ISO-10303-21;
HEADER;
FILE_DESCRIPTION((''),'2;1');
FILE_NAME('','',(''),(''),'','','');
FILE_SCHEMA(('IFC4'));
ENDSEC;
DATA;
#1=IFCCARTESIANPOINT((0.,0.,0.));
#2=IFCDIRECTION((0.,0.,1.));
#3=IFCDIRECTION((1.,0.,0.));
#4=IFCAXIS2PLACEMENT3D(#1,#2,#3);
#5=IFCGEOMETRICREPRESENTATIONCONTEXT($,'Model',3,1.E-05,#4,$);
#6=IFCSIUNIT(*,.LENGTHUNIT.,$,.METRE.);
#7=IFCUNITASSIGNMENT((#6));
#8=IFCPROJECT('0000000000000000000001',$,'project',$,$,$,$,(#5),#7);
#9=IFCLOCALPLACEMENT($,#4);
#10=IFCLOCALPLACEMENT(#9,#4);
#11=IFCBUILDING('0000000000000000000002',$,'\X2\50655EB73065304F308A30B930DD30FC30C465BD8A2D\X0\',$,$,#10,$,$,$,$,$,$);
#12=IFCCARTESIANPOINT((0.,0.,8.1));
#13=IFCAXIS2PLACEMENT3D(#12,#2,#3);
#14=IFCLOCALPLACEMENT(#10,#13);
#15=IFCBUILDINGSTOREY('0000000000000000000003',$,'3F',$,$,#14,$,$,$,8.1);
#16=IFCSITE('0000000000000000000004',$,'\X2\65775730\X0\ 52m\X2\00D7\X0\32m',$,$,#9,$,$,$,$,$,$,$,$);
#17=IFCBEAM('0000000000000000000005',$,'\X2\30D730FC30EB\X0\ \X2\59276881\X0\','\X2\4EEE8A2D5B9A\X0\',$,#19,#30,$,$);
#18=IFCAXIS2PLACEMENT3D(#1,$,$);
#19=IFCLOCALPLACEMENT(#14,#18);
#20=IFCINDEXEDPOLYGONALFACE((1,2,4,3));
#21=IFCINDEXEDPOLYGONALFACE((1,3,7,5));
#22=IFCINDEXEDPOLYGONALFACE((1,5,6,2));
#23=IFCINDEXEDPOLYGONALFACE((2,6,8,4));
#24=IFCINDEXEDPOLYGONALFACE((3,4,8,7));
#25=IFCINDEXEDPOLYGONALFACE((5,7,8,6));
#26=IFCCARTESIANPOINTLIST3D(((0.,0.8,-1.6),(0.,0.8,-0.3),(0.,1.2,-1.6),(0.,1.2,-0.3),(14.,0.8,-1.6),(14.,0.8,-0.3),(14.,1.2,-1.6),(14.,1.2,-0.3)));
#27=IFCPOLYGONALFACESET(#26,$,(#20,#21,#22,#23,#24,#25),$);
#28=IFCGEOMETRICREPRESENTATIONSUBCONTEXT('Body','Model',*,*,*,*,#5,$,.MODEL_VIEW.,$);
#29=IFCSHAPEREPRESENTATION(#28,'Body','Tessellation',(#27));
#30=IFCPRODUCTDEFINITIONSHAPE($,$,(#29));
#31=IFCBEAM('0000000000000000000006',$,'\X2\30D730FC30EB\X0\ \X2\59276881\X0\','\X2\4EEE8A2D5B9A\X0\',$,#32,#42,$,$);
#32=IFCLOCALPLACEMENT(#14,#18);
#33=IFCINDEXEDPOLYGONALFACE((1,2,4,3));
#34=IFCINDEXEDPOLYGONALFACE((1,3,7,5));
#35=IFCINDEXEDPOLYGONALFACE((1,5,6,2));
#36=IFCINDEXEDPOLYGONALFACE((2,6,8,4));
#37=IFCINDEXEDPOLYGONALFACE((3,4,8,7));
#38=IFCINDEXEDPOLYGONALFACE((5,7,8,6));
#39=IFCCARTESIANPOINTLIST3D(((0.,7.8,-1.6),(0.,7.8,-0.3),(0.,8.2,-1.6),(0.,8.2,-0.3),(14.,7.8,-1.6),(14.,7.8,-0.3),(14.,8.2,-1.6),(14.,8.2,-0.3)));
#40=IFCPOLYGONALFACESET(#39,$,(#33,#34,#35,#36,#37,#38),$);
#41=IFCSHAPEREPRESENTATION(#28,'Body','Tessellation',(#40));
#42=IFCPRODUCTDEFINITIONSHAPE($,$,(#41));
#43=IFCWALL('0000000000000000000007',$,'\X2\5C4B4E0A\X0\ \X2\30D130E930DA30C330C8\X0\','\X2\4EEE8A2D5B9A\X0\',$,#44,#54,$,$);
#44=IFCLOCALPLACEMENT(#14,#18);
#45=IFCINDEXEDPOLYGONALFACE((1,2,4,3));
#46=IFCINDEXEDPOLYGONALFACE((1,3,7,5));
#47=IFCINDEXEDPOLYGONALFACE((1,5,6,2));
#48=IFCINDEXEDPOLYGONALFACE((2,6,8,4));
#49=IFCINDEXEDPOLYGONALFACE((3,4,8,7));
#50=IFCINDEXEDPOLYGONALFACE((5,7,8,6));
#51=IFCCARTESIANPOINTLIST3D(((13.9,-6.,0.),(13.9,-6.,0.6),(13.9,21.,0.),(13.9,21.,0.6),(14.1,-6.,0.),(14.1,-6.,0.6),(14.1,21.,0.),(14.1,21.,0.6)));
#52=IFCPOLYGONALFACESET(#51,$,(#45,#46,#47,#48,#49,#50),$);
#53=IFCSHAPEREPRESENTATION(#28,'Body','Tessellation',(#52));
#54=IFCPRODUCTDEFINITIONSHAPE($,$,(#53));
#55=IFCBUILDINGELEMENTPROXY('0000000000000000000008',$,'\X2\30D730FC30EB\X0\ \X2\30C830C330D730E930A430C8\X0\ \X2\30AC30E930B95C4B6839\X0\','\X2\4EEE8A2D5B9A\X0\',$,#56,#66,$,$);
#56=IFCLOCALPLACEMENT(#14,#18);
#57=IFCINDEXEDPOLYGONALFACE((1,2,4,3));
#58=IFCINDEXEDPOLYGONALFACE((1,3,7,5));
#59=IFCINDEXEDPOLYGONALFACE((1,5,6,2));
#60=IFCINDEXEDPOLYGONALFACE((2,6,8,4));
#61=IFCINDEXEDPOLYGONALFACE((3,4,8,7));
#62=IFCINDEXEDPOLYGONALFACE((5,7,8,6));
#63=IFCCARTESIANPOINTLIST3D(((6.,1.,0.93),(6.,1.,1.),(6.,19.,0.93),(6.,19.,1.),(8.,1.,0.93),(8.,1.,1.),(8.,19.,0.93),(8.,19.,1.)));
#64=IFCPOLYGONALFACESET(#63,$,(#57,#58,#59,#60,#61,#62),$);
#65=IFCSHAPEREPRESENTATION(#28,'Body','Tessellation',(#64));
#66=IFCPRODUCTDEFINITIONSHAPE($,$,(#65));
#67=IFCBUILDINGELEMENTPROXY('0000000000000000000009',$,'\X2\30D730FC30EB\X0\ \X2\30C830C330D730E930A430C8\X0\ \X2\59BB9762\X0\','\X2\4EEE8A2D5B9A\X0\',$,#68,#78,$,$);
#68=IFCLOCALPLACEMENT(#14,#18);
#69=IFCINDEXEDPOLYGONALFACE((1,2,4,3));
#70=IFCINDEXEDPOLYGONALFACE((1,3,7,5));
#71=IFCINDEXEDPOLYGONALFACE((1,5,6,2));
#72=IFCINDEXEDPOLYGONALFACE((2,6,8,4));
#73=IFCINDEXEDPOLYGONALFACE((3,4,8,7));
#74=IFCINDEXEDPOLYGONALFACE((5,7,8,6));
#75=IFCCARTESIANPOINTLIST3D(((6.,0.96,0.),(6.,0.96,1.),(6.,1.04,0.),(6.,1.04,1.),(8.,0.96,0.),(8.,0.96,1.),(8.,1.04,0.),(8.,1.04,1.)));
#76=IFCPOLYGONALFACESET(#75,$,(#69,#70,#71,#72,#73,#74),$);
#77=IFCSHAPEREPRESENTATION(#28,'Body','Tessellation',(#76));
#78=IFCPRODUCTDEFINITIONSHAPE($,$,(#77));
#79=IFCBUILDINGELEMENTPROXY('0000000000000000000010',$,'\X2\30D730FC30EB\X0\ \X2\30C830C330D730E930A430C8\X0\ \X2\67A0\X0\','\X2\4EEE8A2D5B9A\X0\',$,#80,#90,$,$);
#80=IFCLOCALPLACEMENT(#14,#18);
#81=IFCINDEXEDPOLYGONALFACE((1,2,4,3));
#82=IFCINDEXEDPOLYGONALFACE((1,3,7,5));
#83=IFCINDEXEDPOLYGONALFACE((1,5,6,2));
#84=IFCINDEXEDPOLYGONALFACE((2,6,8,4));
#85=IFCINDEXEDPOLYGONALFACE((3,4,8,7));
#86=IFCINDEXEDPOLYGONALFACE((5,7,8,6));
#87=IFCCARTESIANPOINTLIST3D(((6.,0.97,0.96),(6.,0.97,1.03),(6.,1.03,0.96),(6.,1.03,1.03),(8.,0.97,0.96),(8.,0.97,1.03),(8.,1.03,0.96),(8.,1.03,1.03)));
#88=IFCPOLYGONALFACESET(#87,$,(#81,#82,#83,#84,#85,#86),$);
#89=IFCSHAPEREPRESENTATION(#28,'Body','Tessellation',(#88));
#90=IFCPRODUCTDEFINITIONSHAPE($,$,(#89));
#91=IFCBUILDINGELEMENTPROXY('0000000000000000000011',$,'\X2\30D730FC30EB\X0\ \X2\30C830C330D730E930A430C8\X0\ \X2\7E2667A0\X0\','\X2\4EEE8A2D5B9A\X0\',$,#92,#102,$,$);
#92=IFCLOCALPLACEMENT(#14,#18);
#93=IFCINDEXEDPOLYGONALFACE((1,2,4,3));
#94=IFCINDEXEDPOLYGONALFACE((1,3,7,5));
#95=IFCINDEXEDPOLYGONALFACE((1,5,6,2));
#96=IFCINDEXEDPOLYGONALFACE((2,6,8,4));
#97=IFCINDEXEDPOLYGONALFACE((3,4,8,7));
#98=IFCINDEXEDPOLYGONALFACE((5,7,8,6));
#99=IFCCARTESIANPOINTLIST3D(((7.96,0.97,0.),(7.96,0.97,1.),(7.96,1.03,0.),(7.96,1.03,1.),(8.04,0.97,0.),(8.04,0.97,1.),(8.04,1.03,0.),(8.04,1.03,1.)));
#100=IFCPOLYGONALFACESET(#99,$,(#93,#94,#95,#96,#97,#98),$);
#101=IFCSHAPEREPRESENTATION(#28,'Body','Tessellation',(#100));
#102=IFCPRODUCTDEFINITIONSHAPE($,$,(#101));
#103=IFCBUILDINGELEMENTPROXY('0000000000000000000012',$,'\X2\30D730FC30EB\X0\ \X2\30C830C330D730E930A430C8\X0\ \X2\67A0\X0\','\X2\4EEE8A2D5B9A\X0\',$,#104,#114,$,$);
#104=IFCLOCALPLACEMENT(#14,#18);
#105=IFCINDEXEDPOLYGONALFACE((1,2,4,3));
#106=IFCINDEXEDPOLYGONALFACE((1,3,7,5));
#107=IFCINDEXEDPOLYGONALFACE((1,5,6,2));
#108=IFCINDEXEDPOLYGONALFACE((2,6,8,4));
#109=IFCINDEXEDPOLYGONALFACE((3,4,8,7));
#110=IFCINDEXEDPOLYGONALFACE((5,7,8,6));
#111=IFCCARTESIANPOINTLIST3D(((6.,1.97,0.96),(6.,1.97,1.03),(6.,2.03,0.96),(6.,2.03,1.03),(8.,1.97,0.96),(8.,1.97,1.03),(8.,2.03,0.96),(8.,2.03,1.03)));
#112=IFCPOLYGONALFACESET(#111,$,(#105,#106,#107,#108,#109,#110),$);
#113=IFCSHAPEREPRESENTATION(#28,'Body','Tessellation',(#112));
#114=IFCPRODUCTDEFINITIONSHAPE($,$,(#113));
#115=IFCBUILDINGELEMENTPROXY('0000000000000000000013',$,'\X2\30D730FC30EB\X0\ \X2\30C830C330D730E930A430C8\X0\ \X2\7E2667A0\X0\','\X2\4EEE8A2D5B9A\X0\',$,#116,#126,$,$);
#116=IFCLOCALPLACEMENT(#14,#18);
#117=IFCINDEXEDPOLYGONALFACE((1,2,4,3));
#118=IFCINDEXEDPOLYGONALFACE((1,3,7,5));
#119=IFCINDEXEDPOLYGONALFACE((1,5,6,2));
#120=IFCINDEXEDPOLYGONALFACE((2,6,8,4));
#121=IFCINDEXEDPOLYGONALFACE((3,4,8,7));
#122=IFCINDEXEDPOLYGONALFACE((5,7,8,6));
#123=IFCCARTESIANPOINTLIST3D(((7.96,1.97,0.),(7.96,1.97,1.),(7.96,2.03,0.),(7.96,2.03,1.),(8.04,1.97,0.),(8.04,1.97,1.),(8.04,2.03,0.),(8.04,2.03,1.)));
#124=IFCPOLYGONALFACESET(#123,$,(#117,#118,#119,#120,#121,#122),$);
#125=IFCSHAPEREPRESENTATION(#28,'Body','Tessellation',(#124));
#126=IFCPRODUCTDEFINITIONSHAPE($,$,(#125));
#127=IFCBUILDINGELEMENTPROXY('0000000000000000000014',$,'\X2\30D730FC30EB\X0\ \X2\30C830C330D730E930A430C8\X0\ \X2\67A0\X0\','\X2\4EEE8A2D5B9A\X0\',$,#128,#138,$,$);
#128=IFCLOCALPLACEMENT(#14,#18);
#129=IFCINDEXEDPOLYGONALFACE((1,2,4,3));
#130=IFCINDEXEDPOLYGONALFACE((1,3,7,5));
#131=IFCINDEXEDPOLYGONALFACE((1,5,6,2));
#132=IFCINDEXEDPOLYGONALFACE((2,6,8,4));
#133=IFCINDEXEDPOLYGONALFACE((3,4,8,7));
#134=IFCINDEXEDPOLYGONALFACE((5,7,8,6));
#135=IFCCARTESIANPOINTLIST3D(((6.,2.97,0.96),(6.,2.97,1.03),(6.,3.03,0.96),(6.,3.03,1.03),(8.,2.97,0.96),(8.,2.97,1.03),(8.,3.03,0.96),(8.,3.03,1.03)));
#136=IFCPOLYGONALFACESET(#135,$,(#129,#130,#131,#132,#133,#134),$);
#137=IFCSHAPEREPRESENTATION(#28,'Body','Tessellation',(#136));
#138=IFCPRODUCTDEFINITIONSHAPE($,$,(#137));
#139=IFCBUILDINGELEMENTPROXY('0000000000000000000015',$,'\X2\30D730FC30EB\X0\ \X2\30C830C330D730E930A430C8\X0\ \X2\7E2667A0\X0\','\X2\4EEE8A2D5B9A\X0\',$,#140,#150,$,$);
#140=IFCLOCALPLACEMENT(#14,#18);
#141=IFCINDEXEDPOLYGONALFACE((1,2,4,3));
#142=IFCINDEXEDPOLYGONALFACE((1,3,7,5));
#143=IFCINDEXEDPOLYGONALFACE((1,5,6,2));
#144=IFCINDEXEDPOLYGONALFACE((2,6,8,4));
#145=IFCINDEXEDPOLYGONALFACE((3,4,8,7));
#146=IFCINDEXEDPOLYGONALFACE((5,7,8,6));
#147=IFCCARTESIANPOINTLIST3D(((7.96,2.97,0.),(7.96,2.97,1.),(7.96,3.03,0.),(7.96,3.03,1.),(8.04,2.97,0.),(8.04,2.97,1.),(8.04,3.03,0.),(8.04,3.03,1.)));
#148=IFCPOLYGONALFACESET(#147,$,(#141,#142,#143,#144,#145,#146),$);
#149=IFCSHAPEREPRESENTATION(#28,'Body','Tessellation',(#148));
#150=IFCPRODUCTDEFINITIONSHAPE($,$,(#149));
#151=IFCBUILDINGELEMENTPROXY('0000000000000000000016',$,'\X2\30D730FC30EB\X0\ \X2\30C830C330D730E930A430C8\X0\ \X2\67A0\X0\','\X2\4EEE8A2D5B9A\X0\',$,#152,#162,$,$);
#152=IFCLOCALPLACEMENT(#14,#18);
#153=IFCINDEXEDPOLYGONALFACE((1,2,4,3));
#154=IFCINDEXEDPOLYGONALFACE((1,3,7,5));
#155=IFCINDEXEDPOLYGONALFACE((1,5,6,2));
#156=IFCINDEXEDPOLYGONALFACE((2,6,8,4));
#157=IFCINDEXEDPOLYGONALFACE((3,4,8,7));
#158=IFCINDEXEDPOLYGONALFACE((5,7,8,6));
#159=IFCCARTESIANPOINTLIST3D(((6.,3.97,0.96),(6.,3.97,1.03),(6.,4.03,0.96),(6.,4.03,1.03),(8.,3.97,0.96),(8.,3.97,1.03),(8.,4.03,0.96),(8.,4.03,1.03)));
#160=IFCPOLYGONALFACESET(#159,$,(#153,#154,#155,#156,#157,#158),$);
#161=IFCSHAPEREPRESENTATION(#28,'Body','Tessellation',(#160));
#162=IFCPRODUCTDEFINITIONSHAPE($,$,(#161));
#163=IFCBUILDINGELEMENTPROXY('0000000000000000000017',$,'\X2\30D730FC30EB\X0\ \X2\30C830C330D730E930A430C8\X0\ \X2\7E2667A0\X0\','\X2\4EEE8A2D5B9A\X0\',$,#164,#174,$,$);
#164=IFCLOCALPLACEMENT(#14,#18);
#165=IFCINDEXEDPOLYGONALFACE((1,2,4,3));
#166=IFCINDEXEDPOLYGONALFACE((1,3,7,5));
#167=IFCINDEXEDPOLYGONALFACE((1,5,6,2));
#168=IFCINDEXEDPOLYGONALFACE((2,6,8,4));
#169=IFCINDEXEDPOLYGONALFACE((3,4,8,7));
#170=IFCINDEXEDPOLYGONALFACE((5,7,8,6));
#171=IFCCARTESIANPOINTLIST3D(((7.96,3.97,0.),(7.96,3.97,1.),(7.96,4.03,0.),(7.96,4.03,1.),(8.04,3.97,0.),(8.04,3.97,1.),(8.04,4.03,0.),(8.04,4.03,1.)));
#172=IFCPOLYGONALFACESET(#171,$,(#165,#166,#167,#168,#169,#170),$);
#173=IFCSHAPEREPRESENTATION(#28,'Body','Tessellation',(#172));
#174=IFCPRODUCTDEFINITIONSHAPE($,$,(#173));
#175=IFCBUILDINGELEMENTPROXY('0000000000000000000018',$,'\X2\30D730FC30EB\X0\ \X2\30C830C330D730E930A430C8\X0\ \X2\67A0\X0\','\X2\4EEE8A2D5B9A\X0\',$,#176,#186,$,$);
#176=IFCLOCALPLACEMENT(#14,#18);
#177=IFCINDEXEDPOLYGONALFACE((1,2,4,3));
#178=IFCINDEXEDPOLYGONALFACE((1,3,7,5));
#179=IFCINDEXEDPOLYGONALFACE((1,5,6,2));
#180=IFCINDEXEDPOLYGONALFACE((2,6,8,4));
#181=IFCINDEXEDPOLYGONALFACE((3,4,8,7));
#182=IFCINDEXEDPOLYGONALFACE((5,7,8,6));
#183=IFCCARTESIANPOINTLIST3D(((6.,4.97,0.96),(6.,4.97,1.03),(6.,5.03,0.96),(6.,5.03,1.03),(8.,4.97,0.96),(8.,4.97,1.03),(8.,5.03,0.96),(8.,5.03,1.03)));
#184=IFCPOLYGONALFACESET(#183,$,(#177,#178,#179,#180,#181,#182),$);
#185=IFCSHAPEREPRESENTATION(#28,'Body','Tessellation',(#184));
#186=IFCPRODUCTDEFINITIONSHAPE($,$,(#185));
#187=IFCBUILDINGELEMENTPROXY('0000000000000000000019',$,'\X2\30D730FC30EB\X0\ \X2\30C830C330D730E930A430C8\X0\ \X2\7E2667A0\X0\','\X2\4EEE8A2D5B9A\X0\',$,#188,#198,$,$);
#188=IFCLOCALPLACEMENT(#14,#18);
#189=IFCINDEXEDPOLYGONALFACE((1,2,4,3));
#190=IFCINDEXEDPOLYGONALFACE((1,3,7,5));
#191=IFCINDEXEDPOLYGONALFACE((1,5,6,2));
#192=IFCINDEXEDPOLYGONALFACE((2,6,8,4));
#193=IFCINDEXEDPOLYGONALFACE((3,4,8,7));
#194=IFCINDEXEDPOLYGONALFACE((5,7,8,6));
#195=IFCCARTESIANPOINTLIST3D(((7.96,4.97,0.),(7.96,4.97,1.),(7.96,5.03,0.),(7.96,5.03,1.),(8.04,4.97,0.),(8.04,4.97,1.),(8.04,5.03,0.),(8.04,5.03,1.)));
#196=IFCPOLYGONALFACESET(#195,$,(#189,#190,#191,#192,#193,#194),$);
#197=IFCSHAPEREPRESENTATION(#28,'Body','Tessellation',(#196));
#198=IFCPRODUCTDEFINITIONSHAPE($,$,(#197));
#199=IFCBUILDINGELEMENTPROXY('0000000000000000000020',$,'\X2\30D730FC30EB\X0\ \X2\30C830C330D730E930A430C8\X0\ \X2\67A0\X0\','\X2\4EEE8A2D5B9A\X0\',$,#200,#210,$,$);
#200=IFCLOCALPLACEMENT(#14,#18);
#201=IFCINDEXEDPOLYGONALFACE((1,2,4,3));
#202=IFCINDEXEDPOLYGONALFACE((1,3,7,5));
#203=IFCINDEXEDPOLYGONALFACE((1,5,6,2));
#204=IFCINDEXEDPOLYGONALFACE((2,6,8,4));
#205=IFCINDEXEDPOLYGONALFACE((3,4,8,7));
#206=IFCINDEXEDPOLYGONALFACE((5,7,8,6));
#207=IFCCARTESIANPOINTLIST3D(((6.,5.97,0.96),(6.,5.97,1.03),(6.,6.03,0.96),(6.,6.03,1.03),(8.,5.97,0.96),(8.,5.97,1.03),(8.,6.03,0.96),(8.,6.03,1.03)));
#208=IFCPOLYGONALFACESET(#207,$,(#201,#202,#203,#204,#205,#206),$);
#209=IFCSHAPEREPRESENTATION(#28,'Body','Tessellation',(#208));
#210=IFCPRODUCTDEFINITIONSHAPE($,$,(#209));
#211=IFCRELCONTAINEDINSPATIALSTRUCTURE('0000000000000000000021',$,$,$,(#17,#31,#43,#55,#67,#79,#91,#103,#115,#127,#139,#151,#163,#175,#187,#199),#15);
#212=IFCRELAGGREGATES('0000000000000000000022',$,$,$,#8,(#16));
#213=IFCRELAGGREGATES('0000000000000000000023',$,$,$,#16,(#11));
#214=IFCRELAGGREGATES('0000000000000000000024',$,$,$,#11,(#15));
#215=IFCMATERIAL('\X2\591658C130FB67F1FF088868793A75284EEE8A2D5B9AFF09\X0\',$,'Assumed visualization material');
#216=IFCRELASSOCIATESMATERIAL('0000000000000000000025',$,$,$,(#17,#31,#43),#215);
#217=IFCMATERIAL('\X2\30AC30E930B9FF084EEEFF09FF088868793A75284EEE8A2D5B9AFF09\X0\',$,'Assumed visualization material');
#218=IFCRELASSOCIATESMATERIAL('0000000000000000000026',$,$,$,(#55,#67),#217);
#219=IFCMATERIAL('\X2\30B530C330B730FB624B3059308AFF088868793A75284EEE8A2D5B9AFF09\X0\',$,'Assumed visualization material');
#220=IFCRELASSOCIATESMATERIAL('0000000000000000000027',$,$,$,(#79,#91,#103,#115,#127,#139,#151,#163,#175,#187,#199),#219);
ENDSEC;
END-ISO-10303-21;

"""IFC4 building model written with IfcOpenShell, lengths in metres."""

from ifc_helpers import new_model, si_unit, frame, origin_with_axes, place, context, subcontext, project, spatial, rectangle, extrude, material, element, save


model = new_model("IFC4")

# Units and contexts
model_context = context("Model", 3, precision=1e-05, world=origin_with_axes())
body_context = subcontext(model_context, "Body", "Model", "MODEL_VIEW")
ifc_project = project(units=[si_unit("LENGTHUNIT", "METRE")], contexts=[model_context])

# Site, building, storey
site_placement = place(None, origin_with_axes())
site = spatial("IfcSite", under=ifc_project, at=site_placement, Name="敷地 52m×32m")
building_placement = place(site_placement, origin_with_axes())
building = spatial("IfcBuilding", under=site, at=building_placement, Name="健康づくりスポーツ施設")
storey_placement = place(building_placement, frame((0.0, 0.0, 8.1), z_axis=(0.0, 0.0, 1.0), x_axis=(1.0, 0.0, 0.0)))
storey = spatial("IfcBuildingStorey", under=building, at=storey_placement, Name="3F", Elevation=8.1)

# Beams
ifc_material_1 = material(Name="外壁・柱（表示用仮設定）", Category="Assumed visualization material")
for number, where, z_axis, x_axis, name in (
    (1, (7.0, 1.0, -1.6), (0.0, 0.0, 1.0), (1.0, 0.0, 0.0), "プール 大梁"),
    (2, (7.0, 8.0, -1.6), (0.0, 0.0, 1.0), (1.0, 0.0, 0.0), "プール 大梁"),
):
    element("IfcBeam", number, at=place(storey_placement, frame(where, z_axis=z_axis, x_axis=x_axis)), inside=storey, material=ifc_material_1, Name=name, Description="仮設定", context=body_context, shape_type="SweptSolid", body=[
        extrude(rectangle(XDim=14.0, YDim=0.4), origin_with_axes(), (0.0, 0.0, 1.0), 1.3),
    ])

# Wall
wall_placement = place(storey_placement, frame((14.0, 7.5, 0.0), z_axis=(0.0, 0.0, 1.0), x_axis=(1.0, 0.0, 0.0)))
element("IfcWall", 3, at=wall_placement, inside=storey, material=ifc_material_1, Name="屋上 パラペット", Description="仮設定", context=body_context, shape_type="SweptSolid", body=[
    extrude(rectangle(XDim=0.2, YDim=27.0), origin_with_axes(), (0.0, 0.0, 1.0), 0.6),
])

# Building element proxies
ifc_material_2 = material(Name="ガラス（仮）（表示用仮設定）", Category="Assumed visualization material")
proxy_1_placement = place(storey_placement, frame((7.0, 10.0, 0.93), z_axis=(0.0, 0.0, 1.0), x_axis=(1.0, 0.0, 0.0)))
element("IfcBuildingElementProxy", 4, at=proxy_1_placement, inside=storey, material=ifc_material_2, Name="プール トップライト ガラス屋根", Description="仮設定", context=body_context, shape_type="SweptSolid", body=[
    extrude(rectangle(XDim=2.0, YDim=18.0), origin_with_axes(), (0.0, 0.0, 1.0), 0.07),
])
proxy_2_placement = place(storey_placement, frame((7.0, 1.0, 0.0), z_axis=(0.0, 0.0, 1.0), x_axis=(1.0, 0.0, 0.0)))
element("IfcBuildingElementProxy", 5, at=proxy_2_placement, inside=storey, material=ifc_material_2, Name="プール トップライト 妻面", Description="仮設定", context=body_context, shape_type="SweptSolid", body=[
    extrude(rectangle(XDim=2.0, YDim=0.08), origin_with_axes(), (0.0, 0.0, 1.0), 1.0),
])
ifc_material_3 = material(Name="サッシ・手すり（表示用仮設定）", Category="Assumed visualization material")
proxy_3_placement = place(storey_placement, frame((7.0, 1.0, 0.96), z_axis=(0.0, 0.0, 1.0), x_axis=(1.0, 0.0, 0.0)))
element("IfcBuildingElementProxy", 6, at=proxy_3_placement, inside=storey, material=ifc_material_3, Name="プール トップライト 枠", Description="仮設定", context=body_context, shape_type="SweptSolid", body=[
    extrude(rectangle(XDim=2.0, YDim=0.06), origin_with_axes(), (0.0, 0.0, 1.0), 0.07),
])
proxy_4_placement = place(storey_placement, frame((8.0, 1.0, 0.0), z_axis=(0.0, 0.0, 1.0), x_axis=(1.0, 0.0, 0.0)))
element("IfcBuildingElementProxy", 7, at=proxy_4_placement, inside=storey, material=ifc_material_3, Name="プール トップライト 縦枠", Description="仮設定", context=body_context, shape_type="SweptSolid", body=[
    extrude(rectangle(XDim=0.08, YDim=0.06), origin_with_axes(), (0.0, 0.0, 1.0), 1.0),
])
proxy_5_placement = place(storey_placement, frame((7.0, 2.0, 0.96), z_axis=(0.0, 0.0, 1.0), x_axis=(1.0, 0.0, 0.0)))
element("IfcBuildingElementProxy", 8, at=proxy_5_placement, inside=storey, material=ifc_material_3, Name="プール トップライト 枠", Description="仮設定", context=body_context, shape_type="SweptSolid", body=[
    extrude(rectangle(XDim=2.0, YDim=0.06), origin_with_axes(), (0.0, 0.0, 1.0), 0.07),
])
proxy_6_placement = place(storey_placement, frame((8.0, 2.0, 0.0), z_axis=(0.0, 0.0, 1.0), x_axis=(1.0, 0.0, 0.0)))
element("IfcBuildingElementProxy", 9, at=proxy_6_placement, inside=storey, material=ifc_material_3, Name="プール トップライト 縦枠", Description="仮設定", context=body_context, shape_type="SweptSolid", body=[
    extrude(rectangle(XDim=0.08, YDim=0.06), origin_with_axes(), (0.0, 0.0, 1.0), 1.0),
])
proxy_7_placement = place(storey_placement, frame((7.0, 3.0, 0.96), z_axis=(0.0, 0.0, 1.0), x_axis=(1.0, 0.0, 0.0)))
element("IfcBuildingElementProxy", 10, at=proxy_7_placement, inside=storey, material=ifc_material_3, Name="プール トップライト 枠", Description="仮設定", context=body_context, shape_type="SweptSolid", body=[
    extrude(rectangle(XDim=2.0, YDim=0.06), origin_with_axes(), (0.0, 0.0, 1.0), 0.07),
])
proxy_8_placement = place(storey_placement, frame((8.0, 3.0, 0.0), z_axis=(0.0, 0.0, 1.0), x_axis=(1.0, 0.0, 0.0)))
element("IfcBuildingElementProxy", 11, at=proxy_8_placement, inside=storey, material=ifc_material_3, Name="プール トップライト 縦枠", Description="仮設定", context=body_context, shape_type="SweptSolid", body=[
    extrude(rectangle(XDim=0.08, YDim=0.06), origin_with_axes(), (0.0, 0.0, 1.0), 1.0),
])
proxy_9_placement = place(storey_placement, frame((7.0, 4.0, 0.96), z_axis=(0.0, 0.0, 1.0), x_axis=(1.0, 0.0, 0.0)))
element("IfcBuildingElementProxy", 12, at=proxy_9_placement, inside=storey, material=ifc_material_3, Name="プール トップライト 枠", Description="仮設定", context=body_context, shape_type="SweptSolid", body=[
    extrude(rectangle(XDim=2.0, YDim=0.06), origin_with_axes(), (0.0, 0.0, 1.0), 0.07),
])
proxy_10_placement = place(storey_placement, frame((8.0, 4.0, 0.0), z_axis=(0.0, 0.0, 1.0), x_axis=(1.0, 0.0, 0.0)))
element("IfcBuildingElementProxy", 13, at=proxy_10_placement, inside=storey, material=ifc_material_3, Name="プール トップライト 縦枠", Description="仮設定", context=body_context, shape_type="SweptSolid", body=[
    extrude(rectangle(XDim=0.08, YDim=0.06), origin_with_axes(), (0.0, 0.0, 1.0), 1.0),
])
proxy_11_placement = place(storey_placement, frame((7.0, 5.0, 0.96), z_axis=(0.0, 0.0, 1.0), x_axis=(1.0, 0.0, 0.0)))
element("IfcBuildingElementProxy", 14, at=proxy_11_placement, inside=storey, material=ifc_material_3, Name="プール トップライト 枠", Description="仮設定", context=body_context, shape_type="SweptSolid", body=[
    extrude(rectangle(XDim=2.0, YDim=0.06), origin_with_axes(), (0.0, 0.0, 1.0), 0.07),
])
proxy_12_placement = place(storey_placement, frame((8.0, 5.0, 0.0), z_axis=(0.0, 0.0, 1.0), x_axis=(1.0, 0.0, 0.0)))
element("IfcBuildingElementProxy", 15, at=proxy_12_placement, inside=storey, material=ifc_material_3, Name="プール トップライト 縦枠", Description="仮設定", context=body_context, shape_type="SweptSolid", body=[
    extrude(rectangle(XDim=0.08, YDim=0.06), origin_with_axes(), (0.0, 0.0, 1.0), 1.0),
])
proxy_13_placement = place(storey_placement, frame((7.0, 6.0, 0.96), z_axis=(0.0, 0.0, 1.0), x_axis=(1.0, 0.0, 0.0)))
element("IfcBuildingElementProxy", 16, at=proxy_13_placement, inside=storey, material=ifc_material_3, Name="プール トップライト 枠", Description="仮設定", context=body_context, shape_type="SweptSolid", body=[
    extrude(rectangle(XDim=2.0, YDim=0.06), origin_with_axes(), (0.0, 0.0, 1.0), 0.07),
])

save(model, "model.ifc")
